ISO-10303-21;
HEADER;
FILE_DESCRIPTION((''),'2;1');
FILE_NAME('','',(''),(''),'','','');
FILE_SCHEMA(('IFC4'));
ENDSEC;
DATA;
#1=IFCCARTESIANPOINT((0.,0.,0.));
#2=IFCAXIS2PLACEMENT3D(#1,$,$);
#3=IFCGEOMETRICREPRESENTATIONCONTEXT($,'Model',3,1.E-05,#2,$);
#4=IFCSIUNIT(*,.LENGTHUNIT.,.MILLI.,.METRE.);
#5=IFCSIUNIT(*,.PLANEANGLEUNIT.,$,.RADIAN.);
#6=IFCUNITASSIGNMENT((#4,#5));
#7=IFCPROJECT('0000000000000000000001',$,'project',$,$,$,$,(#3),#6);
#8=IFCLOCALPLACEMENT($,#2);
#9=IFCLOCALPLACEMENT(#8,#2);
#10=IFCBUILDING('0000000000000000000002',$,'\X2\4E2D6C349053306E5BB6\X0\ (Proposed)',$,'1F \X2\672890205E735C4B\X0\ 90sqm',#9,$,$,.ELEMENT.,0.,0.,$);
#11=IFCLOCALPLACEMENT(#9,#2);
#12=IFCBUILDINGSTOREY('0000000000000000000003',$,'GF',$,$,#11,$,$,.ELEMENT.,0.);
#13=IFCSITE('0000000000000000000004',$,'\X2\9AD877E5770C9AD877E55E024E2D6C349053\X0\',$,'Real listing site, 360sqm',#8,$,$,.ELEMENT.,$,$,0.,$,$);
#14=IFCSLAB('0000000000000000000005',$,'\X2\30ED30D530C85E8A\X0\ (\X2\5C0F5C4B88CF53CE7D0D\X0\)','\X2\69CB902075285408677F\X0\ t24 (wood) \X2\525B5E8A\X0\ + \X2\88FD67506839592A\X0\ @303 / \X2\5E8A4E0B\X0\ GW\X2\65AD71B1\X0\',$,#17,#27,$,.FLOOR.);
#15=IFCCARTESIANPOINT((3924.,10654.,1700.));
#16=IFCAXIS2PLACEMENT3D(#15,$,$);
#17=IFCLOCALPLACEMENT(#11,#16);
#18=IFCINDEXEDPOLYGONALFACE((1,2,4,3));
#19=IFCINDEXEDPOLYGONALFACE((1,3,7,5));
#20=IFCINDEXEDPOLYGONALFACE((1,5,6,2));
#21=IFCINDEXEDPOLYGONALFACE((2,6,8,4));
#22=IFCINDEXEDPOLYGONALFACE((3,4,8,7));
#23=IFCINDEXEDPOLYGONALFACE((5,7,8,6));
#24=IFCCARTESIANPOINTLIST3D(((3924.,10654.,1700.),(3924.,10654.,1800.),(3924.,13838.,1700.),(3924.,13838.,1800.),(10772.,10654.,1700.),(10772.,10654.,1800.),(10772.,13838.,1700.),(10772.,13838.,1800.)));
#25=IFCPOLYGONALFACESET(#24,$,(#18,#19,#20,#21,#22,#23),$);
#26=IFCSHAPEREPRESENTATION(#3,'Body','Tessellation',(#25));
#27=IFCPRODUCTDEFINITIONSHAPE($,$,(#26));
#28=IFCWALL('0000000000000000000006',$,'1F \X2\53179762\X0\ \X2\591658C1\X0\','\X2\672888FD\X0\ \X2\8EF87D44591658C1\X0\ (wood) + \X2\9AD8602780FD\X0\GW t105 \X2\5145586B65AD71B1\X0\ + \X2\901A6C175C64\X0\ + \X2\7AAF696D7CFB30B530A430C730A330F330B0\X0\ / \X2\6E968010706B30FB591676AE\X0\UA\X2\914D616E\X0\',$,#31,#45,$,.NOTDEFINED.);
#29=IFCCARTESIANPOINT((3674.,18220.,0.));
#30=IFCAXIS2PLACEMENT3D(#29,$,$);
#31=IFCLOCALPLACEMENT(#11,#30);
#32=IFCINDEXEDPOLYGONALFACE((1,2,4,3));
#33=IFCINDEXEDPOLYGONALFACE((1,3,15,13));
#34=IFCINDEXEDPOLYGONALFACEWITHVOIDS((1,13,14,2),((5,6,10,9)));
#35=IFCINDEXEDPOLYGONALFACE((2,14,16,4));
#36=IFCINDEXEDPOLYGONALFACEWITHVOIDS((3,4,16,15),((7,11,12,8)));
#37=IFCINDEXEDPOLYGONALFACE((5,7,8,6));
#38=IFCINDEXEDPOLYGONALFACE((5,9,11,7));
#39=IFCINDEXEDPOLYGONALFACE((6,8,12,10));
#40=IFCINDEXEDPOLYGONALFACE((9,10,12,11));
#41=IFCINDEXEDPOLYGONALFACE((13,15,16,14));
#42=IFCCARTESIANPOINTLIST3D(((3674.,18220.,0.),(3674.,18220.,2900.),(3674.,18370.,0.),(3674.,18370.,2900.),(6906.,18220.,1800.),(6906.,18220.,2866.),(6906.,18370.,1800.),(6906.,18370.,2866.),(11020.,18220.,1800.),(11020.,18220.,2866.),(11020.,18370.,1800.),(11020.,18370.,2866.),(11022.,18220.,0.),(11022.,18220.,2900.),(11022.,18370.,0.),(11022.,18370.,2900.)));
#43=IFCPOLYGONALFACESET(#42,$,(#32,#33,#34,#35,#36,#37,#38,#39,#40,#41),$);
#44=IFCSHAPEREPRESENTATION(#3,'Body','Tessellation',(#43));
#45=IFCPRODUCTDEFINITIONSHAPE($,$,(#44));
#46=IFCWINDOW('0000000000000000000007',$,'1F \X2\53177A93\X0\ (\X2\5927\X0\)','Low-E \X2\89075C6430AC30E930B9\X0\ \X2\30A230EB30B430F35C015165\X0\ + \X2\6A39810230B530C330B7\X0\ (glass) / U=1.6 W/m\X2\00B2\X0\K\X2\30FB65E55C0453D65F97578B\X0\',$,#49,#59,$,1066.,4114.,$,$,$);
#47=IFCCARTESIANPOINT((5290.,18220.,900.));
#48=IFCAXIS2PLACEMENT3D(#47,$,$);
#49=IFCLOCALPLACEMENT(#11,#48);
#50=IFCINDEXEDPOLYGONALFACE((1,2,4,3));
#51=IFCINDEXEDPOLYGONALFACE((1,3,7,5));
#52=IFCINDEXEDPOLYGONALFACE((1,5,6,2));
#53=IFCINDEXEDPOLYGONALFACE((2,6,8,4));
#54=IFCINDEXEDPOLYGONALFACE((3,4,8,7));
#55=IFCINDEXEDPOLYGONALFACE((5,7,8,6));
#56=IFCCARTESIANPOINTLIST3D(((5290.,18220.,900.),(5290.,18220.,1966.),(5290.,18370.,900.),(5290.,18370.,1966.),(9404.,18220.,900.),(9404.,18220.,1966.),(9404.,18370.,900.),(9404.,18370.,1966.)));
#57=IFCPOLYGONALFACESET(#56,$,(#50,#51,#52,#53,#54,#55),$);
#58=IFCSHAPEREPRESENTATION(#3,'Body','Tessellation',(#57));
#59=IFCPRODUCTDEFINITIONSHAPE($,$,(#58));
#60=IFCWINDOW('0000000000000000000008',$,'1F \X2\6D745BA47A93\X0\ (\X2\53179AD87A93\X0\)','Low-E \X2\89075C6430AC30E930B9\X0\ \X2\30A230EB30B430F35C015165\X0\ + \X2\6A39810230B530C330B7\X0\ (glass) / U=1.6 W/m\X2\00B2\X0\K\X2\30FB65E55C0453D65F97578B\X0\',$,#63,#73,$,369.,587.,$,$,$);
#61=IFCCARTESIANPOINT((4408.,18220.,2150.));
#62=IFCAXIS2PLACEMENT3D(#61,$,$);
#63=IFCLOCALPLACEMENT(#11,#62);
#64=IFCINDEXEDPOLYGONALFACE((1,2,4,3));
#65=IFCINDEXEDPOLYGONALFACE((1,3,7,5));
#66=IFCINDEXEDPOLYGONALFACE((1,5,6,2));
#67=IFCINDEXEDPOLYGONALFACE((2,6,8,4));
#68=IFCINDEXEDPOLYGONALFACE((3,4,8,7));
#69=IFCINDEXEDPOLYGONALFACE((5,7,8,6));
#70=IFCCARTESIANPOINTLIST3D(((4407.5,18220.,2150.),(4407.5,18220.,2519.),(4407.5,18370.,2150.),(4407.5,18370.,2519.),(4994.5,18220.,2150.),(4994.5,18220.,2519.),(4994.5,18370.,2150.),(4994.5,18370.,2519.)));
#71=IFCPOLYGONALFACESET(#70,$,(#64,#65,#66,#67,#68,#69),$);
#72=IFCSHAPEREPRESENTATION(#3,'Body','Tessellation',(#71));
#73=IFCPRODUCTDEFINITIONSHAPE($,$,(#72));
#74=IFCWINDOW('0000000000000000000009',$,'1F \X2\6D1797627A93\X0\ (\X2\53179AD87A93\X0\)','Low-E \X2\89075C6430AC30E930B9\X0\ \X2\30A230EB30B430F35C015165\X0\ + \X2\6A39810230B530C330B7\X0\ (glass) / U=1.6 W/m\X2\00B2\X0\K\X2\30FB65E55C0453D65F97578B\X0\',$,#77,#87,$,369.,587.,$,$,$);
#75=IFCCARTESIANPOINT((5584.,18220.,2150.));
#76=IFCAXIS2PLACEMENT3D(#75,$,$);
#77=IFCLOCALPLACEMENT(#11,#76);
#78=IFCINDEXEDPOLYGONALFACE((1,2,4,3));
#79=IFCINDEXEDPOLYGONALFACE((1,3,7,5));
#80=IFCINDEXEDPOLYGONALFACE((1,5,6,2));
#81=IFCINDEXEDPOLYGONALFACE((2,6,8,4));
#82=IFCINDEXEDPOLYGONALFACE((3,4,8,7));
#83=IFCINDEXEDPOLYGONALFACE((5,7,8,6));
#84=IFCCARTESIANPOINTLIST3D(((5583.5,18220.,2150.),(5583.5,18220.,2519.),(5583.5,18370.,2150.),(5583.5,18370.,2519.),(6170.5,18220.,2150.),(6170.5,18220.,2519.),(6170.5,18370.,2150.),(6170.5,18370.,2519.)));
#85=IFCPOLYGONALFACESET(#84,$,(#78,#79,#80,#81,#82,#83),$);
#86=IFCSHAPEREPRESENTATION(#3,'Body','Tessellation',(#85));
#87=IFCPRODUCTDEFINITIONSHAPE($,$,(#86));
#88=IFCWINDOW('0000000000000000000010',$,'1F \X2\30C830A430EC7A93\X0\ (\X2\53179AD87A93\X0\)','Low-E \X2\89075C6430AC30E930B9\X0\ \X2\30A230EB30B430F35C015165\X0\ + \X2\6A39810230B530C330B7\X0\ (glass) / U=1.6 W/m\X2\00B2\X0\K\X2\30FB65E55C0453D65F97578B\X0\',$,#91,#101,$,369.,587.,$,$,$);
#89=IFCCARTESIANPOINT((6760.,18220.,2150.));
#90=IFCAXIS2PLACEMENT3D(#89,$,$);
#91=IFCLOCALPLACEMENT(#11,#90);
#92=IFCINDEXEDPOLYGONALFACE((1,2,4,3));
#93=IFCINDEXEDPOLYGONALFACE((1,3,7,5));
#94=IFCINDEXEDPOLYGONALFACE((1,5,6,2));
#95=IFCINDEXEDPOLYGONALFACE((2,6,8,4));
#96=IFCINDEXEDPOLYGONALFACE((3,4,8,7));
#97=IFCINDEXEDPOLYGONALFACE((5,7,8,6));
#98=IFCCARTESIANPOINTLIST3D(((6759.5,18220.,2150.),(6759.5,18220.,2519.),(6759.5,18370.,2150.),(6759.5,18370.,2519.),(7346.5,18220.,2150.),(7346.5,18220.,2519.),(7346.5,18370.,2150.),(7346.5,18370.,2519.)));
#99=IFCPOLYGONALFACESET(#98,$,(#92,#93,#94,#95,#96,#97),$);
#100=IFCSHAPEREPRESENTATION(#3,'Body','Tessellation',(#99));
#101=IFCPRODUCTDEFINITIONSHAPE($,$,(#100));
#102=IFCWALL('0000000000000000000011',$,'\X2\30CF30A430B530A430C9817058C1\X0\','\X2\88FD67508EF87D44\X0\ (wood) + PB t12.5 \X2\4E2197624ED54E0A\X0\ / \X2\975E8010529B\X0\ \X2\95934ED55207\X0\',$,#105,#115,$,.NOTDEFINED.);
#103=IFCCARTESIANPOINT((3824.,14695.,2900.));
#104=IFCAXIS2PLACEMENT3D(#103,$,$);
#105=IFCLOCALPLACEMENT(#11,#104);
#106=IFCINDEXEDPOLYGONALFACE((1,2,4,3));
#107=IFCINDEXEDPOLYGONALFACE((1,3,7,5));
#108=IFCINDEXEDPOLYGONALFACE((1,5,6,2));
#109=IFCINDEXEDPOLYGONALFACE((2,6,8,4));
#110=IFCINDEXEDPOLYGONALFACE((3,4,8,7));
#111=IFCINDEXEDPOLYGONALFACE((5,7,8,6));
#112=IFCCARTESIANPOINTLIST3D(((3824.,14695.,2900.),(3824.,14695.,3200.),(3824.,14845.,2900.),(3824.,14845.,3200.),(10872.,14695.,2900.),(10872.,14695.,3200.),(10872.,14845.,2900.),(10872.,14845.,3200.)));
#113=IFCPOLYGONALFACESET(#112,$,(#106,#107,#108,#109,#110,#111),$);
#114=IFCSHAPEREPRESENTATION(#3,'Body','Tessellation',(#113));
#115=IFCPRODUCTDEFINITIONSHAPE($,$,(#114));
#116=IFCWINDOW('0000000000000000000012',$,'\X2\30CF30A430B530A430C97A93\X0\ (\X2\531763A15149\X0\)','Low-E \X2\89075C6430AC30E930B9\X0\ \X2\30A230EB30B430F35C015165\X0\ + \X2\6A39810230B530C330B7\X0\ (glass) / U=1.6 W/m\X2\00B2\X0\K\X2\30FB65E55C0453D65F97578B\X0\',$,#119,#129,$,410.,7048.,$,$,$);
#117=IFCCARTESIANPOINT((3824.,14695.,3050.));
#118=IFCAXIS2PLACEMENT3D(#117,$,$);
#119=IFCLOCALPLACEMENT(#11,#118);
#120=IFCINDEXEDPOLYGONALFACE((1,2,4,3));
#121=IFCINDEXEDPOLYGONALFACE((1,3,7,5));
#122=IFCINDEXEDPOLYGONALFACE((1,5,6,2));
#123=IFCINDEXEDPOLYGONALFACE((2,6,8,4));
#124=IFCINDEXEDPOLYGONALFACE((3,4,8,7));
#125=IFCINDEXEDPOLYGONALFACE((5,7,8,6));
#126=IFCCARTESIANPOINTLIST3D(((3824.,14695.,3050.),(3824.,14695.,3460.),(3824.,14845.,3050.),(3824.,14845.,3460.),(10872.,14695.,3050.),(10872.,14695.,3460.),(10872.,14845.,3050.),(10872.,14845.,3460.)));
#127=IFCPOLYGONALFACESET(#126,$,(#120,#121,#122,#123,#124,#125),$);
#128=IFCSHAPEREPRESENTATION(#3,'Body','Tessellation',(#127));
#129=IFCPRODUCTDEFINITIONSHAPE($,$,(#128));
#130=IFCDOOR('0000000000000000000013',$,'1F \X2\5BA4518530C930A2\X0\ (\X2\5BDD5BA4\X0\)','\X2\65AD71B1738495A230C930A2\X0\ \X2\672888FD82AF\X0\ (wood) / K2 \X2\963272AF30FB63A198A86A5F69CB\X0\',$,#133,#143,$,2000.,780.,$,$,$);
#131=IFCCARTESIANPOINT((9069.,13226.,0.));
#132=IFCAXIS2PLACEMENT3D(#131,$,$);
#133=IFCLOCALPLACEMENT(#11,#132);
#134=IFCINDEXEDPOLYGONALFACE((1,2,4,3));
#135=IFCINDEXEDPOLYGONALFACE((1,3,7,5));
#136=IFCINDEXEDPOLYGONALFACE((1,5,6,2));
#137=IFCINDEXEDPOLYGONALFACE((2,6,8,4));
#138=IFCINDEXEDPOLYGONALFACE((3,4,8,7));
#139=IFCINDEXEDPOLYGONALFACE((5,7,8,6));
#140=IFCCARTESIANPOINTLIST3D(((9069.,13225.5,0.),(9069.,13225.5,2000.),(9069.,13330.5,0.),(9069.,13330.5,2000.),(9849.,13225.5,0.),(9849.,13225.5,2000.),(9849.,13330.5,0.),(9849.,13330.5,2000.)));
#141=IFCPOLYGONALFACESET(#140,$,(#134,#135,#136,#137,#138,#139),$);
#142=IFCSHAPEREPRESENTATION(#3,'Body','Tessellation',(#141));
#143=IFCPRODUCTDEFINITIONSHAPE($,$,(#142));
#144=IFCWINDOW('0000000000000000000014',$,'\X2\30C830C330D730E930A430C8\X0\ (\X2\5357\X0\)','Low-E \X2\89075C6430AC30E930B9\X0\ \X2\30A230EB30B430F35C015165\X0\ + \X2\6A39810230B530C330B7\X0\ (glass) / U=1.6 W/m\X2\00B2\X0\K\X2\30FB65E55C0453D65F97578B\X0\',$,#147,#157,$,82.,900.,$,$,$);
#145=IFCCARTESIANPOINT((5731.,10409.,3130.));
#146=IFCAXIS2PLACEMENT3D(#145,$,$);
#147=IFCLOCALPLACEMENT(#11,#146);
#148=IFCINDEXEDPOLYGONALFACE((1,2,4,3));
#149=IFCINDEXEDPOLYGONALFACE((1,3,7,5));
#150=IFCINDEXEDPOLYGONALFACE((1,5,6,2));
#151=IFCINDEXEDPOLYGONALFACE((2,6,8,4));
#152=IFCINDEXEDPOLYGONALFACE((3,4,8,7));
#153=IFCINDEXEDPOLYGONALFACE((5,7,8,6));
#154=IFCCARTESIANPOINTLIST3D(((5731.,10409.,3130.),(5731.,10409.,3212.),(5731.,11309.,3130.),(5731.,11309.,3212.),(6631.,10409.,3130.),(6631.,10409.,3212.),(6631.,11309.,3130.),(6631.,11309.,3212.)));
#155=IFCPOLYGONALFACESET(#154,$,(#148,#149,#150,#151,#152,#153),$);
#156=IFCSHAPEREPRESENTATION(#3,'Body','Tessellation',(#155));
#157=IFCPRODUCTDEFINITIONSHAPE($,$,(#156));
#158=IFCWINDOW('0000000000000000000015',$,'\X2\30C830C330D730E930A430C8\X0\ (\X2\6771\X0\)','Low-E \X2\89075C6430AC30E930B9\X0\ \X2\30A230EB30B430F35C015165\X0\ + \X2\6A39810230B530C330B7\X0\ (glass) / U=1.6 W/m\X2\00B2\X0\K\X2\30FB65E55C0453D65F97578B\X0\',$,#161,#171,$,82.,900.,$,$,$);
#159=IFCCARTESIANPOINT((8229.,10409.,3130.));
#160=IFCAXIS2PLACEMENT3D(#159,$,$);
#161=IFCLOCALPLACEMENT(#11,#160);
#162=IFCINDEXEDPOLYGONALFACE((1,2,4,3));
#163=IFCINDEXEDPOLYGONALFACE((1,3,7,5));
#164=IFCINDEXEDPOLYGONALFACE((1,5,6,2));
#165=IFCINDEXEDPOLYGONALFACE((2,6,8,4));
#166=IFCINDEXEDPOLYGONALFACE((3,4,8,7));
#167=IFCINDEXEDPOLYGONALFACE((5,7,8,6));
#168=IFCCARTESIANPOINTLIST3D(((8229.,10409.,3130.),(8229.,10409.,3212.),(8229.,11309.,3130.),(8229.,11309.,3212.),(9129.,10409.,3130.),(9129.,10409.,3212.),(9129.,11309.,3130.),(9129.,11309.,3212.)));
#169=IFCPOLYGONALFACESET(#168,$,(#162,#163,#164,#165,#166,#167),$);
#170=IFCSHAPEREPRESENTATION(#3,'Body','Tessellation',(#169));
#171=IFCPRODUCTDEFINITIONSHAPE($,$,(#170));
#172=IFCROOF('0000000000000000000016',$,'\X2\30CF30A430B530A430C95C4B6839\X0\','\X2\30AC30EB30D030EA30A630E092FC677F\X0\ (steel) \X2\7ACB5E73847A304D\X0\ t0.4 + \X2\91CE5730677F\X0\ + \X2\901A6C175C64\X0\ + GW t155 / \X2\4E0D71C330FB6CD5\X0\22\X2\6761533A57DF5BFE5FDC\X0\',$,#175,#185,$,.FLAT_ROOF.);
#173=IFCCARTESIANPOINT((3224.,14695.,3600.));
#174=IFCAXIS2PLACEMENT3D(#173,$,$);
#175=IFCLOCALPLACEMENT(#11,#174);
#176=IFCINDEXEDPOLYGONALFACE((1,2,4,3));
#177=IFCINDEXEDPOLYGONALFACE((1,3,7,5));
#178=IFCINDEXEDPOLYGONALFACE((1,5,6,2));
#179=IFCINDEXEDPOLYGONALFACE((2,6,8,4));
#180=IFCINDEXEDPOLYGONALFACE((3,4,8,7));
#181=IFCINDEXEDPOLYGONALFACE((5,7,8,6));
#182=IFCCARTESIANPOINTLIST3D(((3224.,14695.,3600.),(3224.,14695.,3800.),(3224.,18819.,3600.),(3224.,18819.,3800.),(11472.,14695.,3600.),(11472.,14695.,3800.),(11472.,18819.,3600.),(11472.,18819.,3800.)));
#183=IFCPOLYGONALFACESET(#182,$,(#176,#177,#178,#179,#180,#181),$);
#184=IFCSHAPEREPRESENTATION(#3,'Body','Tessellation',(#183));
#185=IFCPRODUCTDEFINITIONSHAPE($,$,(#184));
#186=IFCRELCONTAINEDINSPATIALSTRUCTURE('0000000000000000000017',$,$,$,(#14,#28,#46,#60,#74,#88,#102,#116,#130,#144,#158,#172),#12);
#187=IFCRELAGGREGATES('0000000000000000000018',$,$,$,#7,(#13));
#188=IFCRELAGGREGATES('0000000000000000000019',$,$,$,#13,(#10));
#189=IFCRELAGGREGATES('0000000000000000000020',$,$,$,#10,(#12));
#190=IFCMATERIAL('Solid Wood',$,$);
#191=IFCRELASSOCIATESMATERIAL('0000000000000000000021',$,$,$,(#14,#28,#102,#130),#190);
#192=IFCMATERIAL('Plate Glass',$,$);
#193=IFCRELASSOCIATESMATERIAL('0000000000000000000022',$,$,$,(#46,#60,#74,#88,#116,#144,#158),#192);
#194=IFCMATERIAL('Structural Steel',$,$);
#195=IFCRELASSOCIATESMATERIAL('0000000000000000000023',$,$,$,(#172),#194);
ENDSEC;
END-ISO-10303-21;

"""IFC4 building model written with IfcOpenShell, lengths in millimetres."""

from ifc_helpers import new_model, si_unit, frame, frame_2d, origin, place, context, project, spatial, rectangle, extrude, material, element, fill, save


model = new_model("IFC4")

# Units and contexts
model_context = context("Model", 3, precision=1e-05, world=origin())
ifc_project = project(units=[si_unit("LENGTHUNIT", "METRE", prefix="MILLI"), si_unit("PLANEANGLEUNIT", "RADIAN")], contexts=[model_context])

# Site, building, storey
site_placement = place(None, origin())
site = spatial("IfcSite", under=ifc_project, at=site_placement, Name="高知県高知市中水道", ObjectType="Real listing site, 360sqm", CompositionType="ELEMENT", RefElevation=0.0)
building_placement = place(site_placement, origin())
building = spatial("IfcBuilding", under=site, at=building_placement, Name="中水道の家 (Proposed)", ObjectType="1F 木造平屋 90sqm", CompositionType="ELEMENT", ElevationOfRefHeight=0.0, ElevationOfTerrain=0.0)
storey_placement = place(building_placement, origin())
storey = spatial("IfcBuildingStorey", under=building, at=storey_placement, Name="GF", CompositionType="ELEMENT", Elevation=0.0)

# Slab
ifc_material_1 = material(Name="Solid Wood")
slab_placement = place(storey_placement, frame((3924.0, 10654.0, 1700.0)))
element("IfcSlab", 1, at=slab_placement, inside=storey, material=ifc_material_1, Name="ロフト床 (小屋裏収納)", Description="構造用合板 t24 (wood) 剛床 + 製材根太 @303 / 床下 GW断熱", PredefinedType="FLOOR", context=model_context, shape_type="SweptSolid", body=[
    extrude(rectangle(XDim=6848.0, YDim=3184.0, at=frame_2d((3424.0, 1592.0))), frame((3924.0, 10654.0, 1700.0)), (0.0, 0.0, 1.0), 100.0),
])

# Wall, openings, windows
wall_1_placement = place(storey_placement, frame((3674.0, 18220.0, 0.0)))
wall_1 = element("IfcWall", 2, at=wall_1_placement, inside=storey, material=ifc_material_1, Name="1F 北面 外壁", Description="木製 軸組外壁 (wood) + 高性能GW t105 充填断熱 + 通気層 + 窯業系サイディング / 準耐火・外皮UA配慮", PredefinedType="NOTDEFINED", context=model_context, shape_type="SweptSolid", body=[
    extrude(rectangle(XDim=7348.0, YDim=150.0, at=frame_2d((3674.0, 75.0))), frame((3674.0, 18220.0, 0.0)), (0.0, 0.0, 1.0), 2900.0),
])
opening_1_placement = place(storey_placement, frame((5290.0, 18220.0, 900.0)))
opening_1 = element("IfcOpeningElement", 3, at=opening_1_placement, cuts=wall_1, PredefinedType="NOTDEFINED", context=model_context, shape_type="SweptSolid", body=[
    extrude(rectangle(XDim=4114.0, YDim=150.0, at=frame_2d((2057.0, 75.0))), frame((5290.0, 18220.0, 900.0)), (0.0, 0.0, 1.0), 1066.0),
])
opening_2_placement = place(storey_placement, frame((4408.0, 18220.0, 2150.0)))
opening_2 = element("IfcOpeningElement", 4, at=opening_2_placement, cuts=wall_1, PredefinedType="NOTDEFINED", context=model_context, shape_type="SweptSolid", body=[
    extrude(rectangle(XDim=587.0, YDim=150.0, at=frame_2d((293.0, 75.0))), frame((4408.0, 18220.0, 2150.0)), (0.0, 0.0, 1.0), 369.0),
])
opening_3_placement = place(storey_placement, frame((5584.0, 18220.0, 2150.0)))
opening_3 = element("IfcOpeningElement", 5, at=opening_3_placement, cuts=wall_1, PredefinedType="NOTDEFINED", context=model_context, shape_type="SweptSolid", body=[
    extrude(rectangle(XDim=587.0, YDim=150.0, at=frame_2d((293.0, 75.0))), frame((5584.0, 18220.0, 2150.0)), (0.0, 0.0, 1.0), 369.0),
])
opening_4_placement = place(storey_placement, frame((6760.0, 18220.0, 2150.0)))
opening_4 = element("IfcOpeningElement", 6, at=opening_4_placement, cuts=wall_1, PredefinedType="NOTDEFINED", context=model_context, shape_type="SweptSolid", body=[
    extrude(rectangle(XDim=587.0, YDim=150.0, at=frame_2d((293.0, 75.0))), frame((6760.0, 18220.0, 2150.0)), (0.0, 0.0, 1.0), 369.0),
])
ifc_material_2 = material(Name="Plate Glass")
window_1_placement = place(storey_placement, frame((5290.0, 18220.0, 900.0)))
window_1 = element("IfcWindow", 7, at=window_1_placement, inside=storey, material=ifc_material_2, Name="1F 北窓 (大)", Description="Low-E 複層ガラス アルゴン封入 + 樹脂サッシ (glass) / U=1.6 W/m²K・日射取得型", OverallHeight=1066.0, OverallWidth=4114.0, context=model_context, shape_type="SweptSolid", body=[
    extrude(rectangle(XDim=4114.0, YDim=150.0, at=frame_2d((2057.0, 75.0))), frame((5290.0, 18220.0, 900.0)), (0.0, 0.0, 1.0), 1066.0),
])
fill(opening_1, window_1)
window_2_placement = place(storey_placement, frame((4408.0, 18220.0, 2150.0)))
window_2 = element("IfcWindow", 8, at=window_2_placement, inside=storey, material=ifc_material_2, Name="1F 浴室窓 (北高窓)", Description="Low-E 複層ガラス アルゴン封入 + 樹脂サッシ (glass) / U=1.6 W/m²K・日射取得型", OverallHeight=369.0, OverallWidth=587.0, context=model_context, shape_type="SweptSolid", body=[
    extrude(rectangle(XDim=587.0, YDim=150.0, at=frame_2d((293.0, 75.0))), frame((4408.0, 18220.0, 2150.0)), (0.0, 0.0, 1.0), 369.0),
])
fill(opening_2, window_2)
window_3_placement = place(storey_placement, frame((5584.0, 18220.0, 2150.0)))
window_3 = element("IfcWindow", 9, at=window_3_placement, inside=storey, material=ifc_material_2, Name="1F 洗面窓 (北高窓)", Description="Low-E 複層ガラス アルゴン封入 + 樹脂サッシ (glass) / U=1.6 W/m²K・日射取得型", OverallHeight=369.0, OverallWidth=587.0, context=model_context, shape_type="SweptSolid", body=[
    extrude(rectangle(XDim=587.0, YDim=150.0, at=frame_2d((293.0, 75.0))), frame((5584.0, 18220.0, 2150.0)), (0.0, 0.0, 1.0), 369.0),
])
fill(opening_3, window_3)
window_4_placement = place(storey_placement, frame((6760.0, 18220.0, 2150.0)))
window_4 = element("IfcWindow", 10, at=window_4_placement, inside=storey, material=ifc_material_2, Name="1F トイレ窓 (北高窓)", Description="Low-E 複層ガラス アルゴン封入 + 樹脂サッシ (glass) / U=1.6 W/m²K・日射取得型", OverallHeight=369.0, OverallWidth=587.0, context=model_context, shape_type="SweptSolid", body=[
    extrude(rectangle(XDim=587.0, YDim=150.0, at=frame_2d((293.0, 75.0))), frame((6760.0, 18220.0, 2150.0)), (0.0, 0.0, 1.0), 369.0),
])
fill(opening_4, window_4)

# Wall, opening, window
wall_2_placement = place(storey_placement, frame((3824.0, 14695.0, 2900.0)))
wall_2 = element("IfcWall", 11, at=wall_2_placement, inside=storey, material=ifc_material_1, Name="ハイサイド腰壁", Description="製材軸組 (wood) + PB t12.5 両面仕上 / 非耐力 間仕切", PredefinedType="NOTDEFINED", context=model_context, shape_type="SweptSolid", body=[
    extrude(rectangle(XDim=7048.0, YDim=150.0, at=frame_2d((3524.0, 75.0))), frame((3824.0, 14695.0, 2900.0)), (0.0, 0.0, 1.0), 700.0),
])
opening_5_placement = place(storey_placement, frame((3824.0, 14695.0, 3050.0)))
opening_5 = element("IfcOpeningElement", 12, at=opening_5_placement, cuts=wall_2, PredefinedType="NOTDEFINED", context=model_context, shape_type="SweptSolid", body=[
    extrude(rectangle(XDim=7048.0, YDim=150.0, at=frame_2d((3524.0, 75.0))), frame((3824.0, 14695.0, 3050.0)), (0.0, 0.0, 1.0), 410.0),
])
window_5_placement = place(storey_placement, frame((3824.0, 14695.0, 3050.0)))
window_5 = element("IfcWindow", 13, at=window_5_placement, inside=storey, material=ifc_material_2, Name="ハイサイド窓 (北採光)", Description="Low-E 複層ガラス アルゴン封入 + 樹脂サッシ (glass) / U=1.6 W/m²K・日射取得型", OverallHeight=410.0, OverallWidth=7048.0, context=model_context, shape_type="SweptSolid", body=[
    extrude(rectangle(XDim=7048.0, YDim=150.0, at=frame_2d((3524.0, 75.0))), frame((3824.0, 14695.0, 3050.0)), (0.0, 0.0, 1.0), 410.0),
])
fill(opening_5, window_5)

# Door
door_1_placement = place(storey_placement, frame((9069.0, 13226.0, 0.0)))
element("IfcDoor", 14, at=door_1_placement, inside=storey, material=ifc_material_1, Name="1F 室内ドア (寝室)", Description="断熱玄関ドア 木製芯 (wood) / K2 防犯・採風機構", OverallHeight=2000.0, OverallWidth=780.0, context=model_context, shape_type="SweptSolid", body=[
    extrude(rectangle(XDim=780.0, YDim=105.0, at=frame_2d((390.0, 52.0))), frame((9069.0, 13226.0, 0.0)), (0.0, 0.0, 1.0), 2000.0),
])

# Windows
window_6_placement = place(storey_placement, frame((5731.0, 10409.0, 3130.0)))
element("IfcWindow", 15, at=window_6_placement, inside=storey, material=ifc_material_2, Name="トップライト (南)", Description="Low-E 複層ガラス アルゴン封入 + 樹脂サッシ (glass) / U=1.6 W/m²K・日射取得型", OverallHeight=82.0, OverallWidth=900.0, context=model_context, shape_type="SweptSolid", body=[
    extrude(rectangle(XDim=900.0, YDim=900.0, at=frame_2d((450.0, 450.0))), frame((5731.0, 10409.0, 3130.0)), (0.0, 0.0, 1.0), 82.0),
])
window_7_placement = place(storey_placement, frame((8229.0, 10409.0, 3130.0)))
element("IfcWindow", 16, at=window_7_placement, inside=storey, material=ifc_material_2, Name="トップライト (東)", Description="Low-E 複層ガラス アルゴン封入 + 樹脂サッシ (glass) / U=1.6 W/m²K・日射取得型", OverallHeight=82.0, OverallWidth=900.0, context=model_context, shape_type="SweptSolid", body=[
    extrude(rectangle(XDim=900.0, YDim=900.0, at=frame_2d((450.0, 450.0))), frame((8229.0, 10409.0, 3130.0)), (0.0, 0.0, 1.0), 82.0),
])

# Roof
ifc_material_3 = material(Name="Structural Steel")
roof_placement = place(storey_placement, frame((3224.0, 14695.0, 3600.0)))
element("IfcRoof", 17, at=roof_placement, inside=storey, material=ifc_material_3, Name="ハイサイド屋根", Description="ガルバリウム鋼板 (steel) 立平葺き t0.4 + 野地板 + 通気層 + GW t155 / 不燃・法22条区域対応", PredefinedType="FLAT_ROOF", context=model_context, shape_type="SweptSolid", body=[
    extrude(rectangle(XDim=8248.0, YDim=4124.0, at=frame_2d((4124.0, 2062.0))), frame((3224.0, 14695.0, 3600.0)), (0.0, 0.0, 1.0), 200.0),
])

save(model, "model.ifc")
